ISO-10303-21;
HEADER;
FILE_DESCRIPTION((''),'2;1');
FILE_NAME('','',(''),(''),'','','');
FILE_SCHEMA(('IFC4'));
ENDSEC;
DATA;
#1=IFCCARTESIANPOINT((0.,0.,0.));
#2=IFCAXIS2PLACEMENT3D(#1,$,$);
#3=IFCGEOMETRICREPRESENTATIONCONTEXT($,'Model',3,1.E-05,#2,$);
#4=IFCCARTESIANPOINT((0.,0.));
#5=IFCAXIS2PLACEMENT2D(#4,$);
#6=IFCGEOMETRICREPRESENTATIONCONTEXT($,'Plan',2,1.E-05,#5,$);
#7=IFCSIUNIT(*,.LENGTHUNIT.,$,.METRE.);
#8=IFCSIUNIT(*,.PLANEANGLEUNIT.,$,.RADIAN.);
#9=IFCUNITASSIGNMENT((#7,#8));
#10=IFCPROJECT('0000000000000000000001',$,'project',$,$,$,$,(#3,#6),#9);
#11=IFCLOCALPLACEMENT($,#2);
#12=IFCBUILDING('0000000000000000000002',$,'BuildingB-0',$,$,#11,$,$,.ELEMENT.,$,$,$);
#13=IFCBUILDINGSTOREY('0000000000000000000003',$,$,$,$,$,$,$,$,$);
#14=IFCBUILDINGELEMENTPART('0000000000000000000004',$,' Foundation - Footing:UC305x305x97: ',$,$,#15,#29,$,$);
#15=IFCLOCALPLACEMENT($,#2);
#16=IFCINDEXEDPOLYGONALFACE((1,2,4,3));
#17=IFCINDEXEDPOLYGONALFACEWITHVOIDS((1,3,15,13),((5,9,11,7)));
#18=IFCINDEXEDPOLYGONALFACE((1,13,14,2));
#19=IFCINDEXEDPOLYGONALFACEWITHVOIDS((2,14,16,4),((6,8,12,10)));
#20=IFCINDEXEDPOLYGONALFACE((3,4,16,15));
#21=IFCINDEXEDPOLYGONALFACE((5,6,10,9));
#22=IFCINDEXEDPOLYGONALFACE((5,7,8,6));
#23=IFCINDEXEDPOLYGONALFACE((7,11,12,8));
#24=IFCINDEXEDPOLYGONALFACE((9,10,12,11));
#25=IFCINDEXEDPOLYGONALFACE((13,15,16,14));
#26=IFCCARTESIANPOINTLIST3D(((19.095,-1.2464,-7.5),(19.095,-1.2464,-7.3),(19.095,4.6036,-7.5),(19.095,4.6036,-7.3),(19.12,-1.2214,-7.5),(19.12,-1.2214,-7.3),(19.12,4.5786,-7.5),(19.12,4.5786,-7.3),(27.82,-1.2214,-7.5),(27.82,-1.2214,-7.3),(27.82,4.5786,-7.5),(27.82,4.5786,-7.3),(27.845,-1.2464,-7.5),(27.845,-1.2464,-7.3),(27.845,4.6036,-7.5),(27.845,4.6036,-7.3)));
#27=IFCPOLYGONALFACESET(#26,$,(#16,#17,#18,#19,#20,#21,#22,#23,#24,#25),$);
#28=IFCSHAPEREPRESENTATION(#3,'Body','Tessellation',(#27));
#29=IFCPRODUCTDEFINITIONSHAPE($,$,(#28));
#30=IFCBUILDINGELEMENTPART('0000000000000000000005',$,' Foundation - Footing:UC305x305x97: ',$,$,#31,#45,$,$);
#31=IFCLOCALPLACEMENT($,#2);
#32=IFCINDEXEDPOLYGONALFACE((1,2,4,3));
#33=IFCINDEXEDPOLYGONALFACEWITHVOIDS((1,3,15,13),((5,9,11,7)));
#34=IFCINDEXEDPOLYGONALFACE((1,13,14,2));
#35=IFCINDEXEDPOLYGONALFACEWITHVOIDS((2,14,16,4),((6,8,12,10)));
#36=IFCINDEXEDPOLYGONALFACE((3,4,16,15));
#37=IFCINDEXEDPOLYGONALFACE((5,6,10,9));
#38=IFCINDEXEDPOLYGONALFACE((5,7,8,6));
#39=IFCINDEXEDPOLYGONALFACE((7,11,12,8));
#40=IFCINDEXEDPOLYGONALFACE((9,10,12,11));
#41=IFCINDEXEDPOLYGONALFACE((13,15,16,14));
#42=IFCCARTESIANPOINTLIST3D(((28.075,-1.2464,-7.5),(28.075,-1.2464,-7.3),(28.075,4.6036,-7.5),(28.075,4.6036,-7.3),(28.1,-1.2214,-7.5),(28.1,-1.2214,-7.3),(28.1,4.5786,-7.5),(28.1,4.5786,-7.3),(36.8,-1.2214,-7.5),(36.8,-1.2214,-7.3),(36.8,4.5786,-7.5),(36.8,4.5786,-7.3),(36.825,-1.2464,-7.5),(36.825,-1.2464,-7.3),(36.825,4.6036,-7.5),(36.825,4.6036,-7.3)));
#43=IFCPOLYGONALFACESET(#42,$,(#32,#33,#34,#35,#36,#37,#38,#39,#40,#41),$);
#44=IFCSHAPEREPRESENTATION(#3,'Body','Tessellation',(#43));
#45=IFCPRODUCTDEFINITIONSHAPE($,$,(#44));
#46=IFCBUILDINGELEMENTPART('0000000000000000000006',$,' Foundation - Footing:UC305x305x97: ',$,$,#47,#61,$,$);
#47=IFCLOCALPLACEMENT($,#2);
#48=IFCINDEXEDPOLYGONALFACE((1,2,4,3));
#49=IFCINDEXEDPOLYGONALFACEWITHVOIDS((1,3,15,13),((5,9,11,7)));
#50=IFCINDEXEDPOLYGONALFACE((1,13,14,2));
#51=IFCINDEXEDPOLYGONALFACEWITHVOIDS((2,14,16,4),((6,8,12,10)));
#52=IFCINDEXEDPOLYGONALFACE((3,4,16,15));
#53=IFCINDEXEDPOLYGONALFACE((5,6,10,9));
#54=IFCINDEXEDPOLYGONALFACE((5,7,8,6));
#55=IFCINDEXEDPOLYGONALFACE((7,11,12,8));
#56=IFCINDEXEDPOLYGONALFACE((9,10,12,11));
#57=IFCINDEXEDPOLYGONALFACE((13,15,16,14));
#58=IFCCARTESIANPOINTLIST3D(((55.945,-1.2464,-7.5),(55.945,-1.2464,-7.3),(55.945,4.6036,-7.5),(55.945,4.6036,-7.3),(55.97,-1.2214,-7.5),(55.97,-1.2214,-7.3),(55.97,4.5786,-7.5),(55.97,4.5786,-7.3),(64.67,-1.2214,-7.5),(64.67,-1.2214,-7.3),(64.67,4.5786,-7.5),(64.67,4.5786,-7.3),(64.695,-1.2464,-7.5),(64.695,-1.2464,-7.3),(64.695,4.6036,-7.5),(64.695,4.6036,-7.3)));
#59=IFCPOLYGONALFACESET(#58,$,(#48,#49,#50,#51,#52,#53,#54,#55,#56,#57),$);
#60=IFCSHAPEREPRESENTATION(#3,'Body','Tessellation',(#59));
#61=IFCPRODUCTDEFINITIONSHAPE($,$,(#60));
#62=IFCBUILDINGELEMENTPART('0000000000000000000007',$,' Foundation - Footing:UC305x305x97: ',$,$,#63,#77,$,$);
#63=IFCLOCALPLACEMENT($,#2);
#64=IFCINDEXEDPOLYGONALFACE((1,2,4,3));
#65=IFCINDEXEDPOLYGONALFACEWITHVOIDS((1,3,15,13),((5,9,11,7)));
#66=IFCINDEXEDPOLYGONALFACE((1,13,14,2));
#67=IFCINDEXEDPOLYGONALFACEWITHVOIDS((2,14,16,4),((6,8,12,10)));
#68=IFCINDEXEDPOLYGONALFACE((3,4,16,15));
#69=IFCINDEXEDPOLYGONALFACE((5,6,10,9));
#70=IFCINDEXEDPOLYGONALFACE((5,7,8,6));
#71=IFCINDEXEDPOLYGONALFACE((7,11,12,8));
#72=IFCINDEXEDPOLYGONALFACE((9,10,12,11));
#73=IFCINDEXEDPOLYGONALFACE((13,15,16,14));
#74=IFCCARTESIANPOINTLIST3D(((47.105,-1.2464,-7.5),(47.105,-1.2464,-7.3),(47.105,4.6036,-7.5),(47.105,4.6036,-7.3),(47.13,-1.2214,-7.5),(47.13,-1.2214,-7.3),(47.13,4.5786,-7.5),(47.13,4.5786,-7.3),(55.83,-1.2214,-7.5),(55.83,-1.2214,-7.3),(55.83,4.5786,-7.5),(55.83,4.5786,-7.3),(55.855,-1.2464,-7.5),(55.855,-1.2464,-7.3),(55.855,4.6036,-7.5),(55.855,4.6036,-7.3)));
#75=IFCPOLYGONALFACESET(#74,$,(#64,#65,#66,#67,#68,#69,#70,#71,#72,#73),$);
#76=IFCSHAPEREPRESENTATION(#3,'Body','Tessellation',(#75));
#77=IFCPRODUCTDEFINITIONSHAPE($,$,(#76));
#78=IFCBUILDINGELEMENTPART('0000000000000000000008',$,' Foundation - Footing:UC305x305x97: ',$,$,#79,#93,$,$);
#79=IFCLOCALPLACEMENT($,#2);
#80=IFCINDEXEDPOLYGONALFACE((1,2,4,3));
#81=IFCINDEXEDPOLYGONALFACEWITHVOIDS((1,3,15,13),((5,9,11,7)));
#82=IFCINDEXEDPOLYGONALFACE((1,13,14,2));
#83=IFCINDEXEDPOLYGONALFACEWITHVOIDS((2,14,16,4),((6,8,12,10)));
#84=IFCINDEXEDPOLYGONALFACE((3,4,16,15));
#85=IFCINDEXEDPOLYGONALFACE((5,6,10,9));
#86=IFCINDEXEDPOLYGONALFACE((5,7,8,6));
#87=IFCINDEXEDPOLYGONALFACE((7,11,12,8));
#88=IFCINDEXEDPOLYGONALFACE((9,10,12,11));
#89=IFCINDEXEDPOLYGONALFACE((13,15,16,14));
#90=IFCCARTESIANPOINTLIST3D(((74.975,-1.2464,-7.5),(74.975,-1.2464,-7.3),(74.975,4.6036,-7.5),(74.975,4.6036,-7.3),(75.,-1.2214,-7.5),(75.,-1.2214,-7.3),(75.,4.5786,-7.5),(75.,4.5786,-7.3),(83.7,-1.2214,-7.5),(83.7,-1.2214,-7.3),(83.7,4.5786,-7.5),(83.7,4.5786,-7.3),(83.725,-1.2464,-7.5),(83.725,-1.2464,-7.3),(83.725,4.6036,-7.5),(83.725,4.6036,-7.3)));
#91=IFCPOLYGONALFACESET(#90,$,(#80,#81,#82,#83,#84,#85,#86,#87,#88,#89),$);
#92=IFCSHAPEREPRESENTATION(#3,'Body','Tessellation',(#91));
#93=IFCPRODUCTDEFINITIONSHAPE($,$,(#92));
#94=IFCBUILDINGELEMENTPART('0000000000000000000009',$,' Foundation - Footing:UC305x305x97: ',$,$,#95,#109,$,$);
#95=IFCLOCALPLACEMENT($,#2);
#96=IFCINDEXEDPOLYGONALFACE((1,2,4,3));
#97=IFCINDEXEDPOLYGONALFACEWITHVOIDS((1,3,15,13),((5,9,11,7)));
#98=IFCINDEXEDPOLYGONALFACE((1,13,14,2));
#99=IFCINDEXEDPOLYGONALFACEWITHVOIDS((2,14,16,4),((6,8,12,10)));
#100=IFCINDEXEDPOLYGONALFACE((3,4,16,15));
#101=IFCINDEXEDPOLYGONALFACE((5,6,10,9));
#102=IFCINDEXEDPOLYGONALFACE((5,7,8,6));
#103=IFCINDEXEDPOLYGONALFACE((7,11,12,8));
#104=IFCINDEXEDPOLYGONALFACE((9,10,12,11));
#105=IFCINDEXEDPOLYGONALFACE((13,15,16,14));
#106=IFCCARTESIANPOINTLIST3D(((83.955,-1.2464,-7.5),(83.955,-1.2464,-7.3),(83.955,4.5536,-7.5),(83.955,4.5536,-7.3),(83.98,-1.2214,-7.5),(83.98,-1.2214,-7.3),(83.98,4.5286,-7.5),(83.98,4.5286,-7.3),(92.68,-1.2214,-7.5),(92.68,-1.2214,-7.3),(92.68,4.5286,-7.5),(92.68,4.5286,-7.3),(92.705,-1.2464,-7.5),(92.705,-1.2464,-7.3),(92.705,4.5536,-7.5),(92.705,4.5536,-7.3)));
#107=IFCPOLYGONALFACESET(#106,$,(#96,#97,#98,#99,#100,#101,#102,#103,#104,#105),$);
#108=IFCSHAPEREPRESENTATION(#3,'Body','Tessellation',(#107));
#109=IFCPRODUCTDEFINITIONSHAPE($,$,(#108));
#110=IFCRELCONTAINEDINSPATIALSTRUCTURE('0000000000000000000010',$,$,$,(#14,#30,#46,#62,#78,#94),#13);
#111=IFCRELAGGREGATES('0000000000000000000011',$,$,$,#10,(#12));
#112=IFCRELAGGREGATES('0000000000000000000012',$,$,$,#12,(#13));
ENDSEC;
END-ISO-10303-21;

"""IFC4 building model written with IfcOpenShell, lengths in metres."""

from ifc_helpers import new_model, si_unit, origin, origin_2d, place, context, project, spatial, polyline, outline, extrude, element, save


model = new_model("IFC4")

# Units and contexts
model_context = context("Model", 3, precision=1e-05, world=origin())
plan_context = context("Plan", 2, precision=1e-05, world=origin_2d())
ifc_project = project(units=[si_unit("LENGTHUNIT", "METRE"), si_unit("PLANEANGLEUNIT", "RADIAN")], contexts=[model_context, plan_context])

# Building, storey
building_placement = place(None, origin())
building = spatial("IfcBuilding", under=ifc_project, at=building_placement, Name="BuildingB-0", CompositionType="ELEMENT")
storey = spatial("IfcBuildingStorey", under=building)

# Building element parts, openings
building_element_part_1 = element("IfcBuildingElementPart", 1, inside=storey, Name=" Foundation - Footing:UC305x305x97: ", context=model_context, shape_type="SweptSolid", body=[
    extrude(outline(polyline([(19.095, -1.2464, -7.5), (27.845, -1.2464, -7.5), (27.845, 4.6036, -7.5), (19.095, 4.6036, -7.5), (19.095, -1.2464, -7.5)])), None, (0.0, 0.0, 1.0), 0.2),
])
element("IfcOpeningElement", 2, inside=storey, cuts=building_element_part_1, context=model_context, shape_type="SweptSolid", body=[
    extrude(outline(polyline([(19.12, -1.2214, -7.5), (27.82, -1.2214, -7.5), (27.82, 4.5786, -7.5), (19.12, 4.5786, -7.5), (19.12, -1.2214, -7.5)])), None, (0.0, 0.0, 1.0), 0.2),
])
building_element_part_2 = element("IfcBuildingElementPart", 3, inside=storey, Name=" Foundation - Footing:UC305x305x97: ", context=model_context, shape_type="SweptSolid", body=[
    extrude(outline(polyline([(28.075, -1.2464, -7.5), (36.825, -1.2464, -7.5), (36.825, 4.6036, -7.5), (28.075, 4.6036, -7.5), (28.075, -1.2464, -7.5)])), None, (0.0, 0.0, 1.0), 0.2),
])
element("IfcOpeningElement", 4, inside=storey, cuts=building_element_part_2, context=model_context, shape_type="SweptSolid", body=[
    extrude(outline(polyline([(28.1, -1.2214, -7.5), (36.8, -1.2214, -7.5), (36.8, 4.5786, -7.5), (28.1, 4.5786, -7.5), (28.1, -1.2214, -7.5)])), None, (0.0, 0.0, 1.0), 0.2),
])
building_element_part_3 = element("IfcBuildingElementPart", 5, inside=storey, Name=" Foundation - Footing:UC305x305x97: ", context=model_context, shape_type="SweptSolid", body=[
    extrude(outline(polyline([(55.945, -1.2464, -7.5), (64.695, -1.2464, -7.5), (64.695, 4.6036, -7.5), (55.945, 4.6036, -7.5), (55.945, -1.2464, -7.5)])), None, (0.0, 0.0, 1.0), 0.2),
])
element("IfcOpeningElement", 6, inside=storey, cuts=building_element_part_3, context=model_context, shape_type="SweptSolid", body=[
    extrude(outline(polyline([(55.97, -1.2214, -7.5), (64.67, -1.2214, -7.5), (64.67, 4.5786, -7.5), (55.97, 4.5786, -7.5), (55.97, -1.2214, -7.5)])), None, (0.0, 0.0, 1.0), 0.2),
])
building_element_part_4 = element("IfcBuildingElementPart", 7, inside=storey, Name=" Foundation - Footing:UC305x305x97: ", context=model_context, shape_type="SweptSolid", body=[
    extrude(outline(polyline([(47.105, -1.2464, -7.5), (55.855, -1.2464, -7.5), (55.855, 4.6036, -7.5), (47.105, 4.6036, -7.5), (47.105, -1.2464, -7.5)])), None, (0.0, 0.0, 1.0), 0.2),
])
element("IfcOpeningElement", 8, inside=storey, cuts=building_element_part_4, context=model_context, shape_type="SweptSolid", body=[
    extrude(outline(polyline([(47.13, -1.2214, -7.5), (55.83, -1.2214, -7.5), (55.83, 4.5786, -7.5), (47.13, 4.5786, -7.5), (47.13, -1.2214, -7.5)])), None, (0.0, 0.0, 1.0), 0.2),
])
building_element_part_5 = element("IfcBuildingElementPart", 9, inside=storey, Name=" Foundation - Footing:UC305x305x97: ", context=model_context, shape_type="SweptSolid", body=[
    extrude(outline(polyline([(74.975, -1.2464, -7.5), (83.725, -1.2464, -7.5), (83.725, 4.6036, -7.5), (74.975, 4.6036, -7.5), (74.975, -1.2464, -7.5)])), None, (0.0, 0.0, 1.0), 0.2),
])
element("IfcOpeningElement", 10, inside=storey, cuts=building_element_part_5, context=model_context, shape_type="SweptSolid", body=[
    extrude(outline(polyline([(75.0, -1.2214, -7.5), (83.7, -1.2214, -7.5), (83.7, 4.5786, -7.5), (75.0, 4.5786, -7.5), (75.0, -1.2214, -7.5)])), None, (0.0, 0.0, 1.0), 0.2),
])
building_element_part_6 = element("IfcBuildingElementPart", 11, inside=storey, Name=" Foundation - Footing:UC305x305x97: ", context=model_context, shape_type="SweptSolid", body=[
    extrude(outline(polyline([(92.705, -1.2464, -7.5), (83.955, -1.2464, -7.5), (83.955, 4.5536, -7.5), (92.705, 4.5536, -7.5), (92.705, -1.2464, -7.5)])), None, (0.0, 0.0, 1.0), 0.2),
])
element("IfcOpeningElement", 12, inside=storey, cuts=building_element_part_6, context=model_context, shape_type="SweptSolid", body=[
    extrude(outline(polyline([(92.68, -1.2214, -7.5), (83.98, -1.2214, -7.5), (83.98, 4.5286, -7.5), (92.68, 4.5286, -7.5), (92.68, -1.2214, -7.5)])), None, (0.0, 0.0, 1.0), 0.2),
])

save(model, "model.ifc")
